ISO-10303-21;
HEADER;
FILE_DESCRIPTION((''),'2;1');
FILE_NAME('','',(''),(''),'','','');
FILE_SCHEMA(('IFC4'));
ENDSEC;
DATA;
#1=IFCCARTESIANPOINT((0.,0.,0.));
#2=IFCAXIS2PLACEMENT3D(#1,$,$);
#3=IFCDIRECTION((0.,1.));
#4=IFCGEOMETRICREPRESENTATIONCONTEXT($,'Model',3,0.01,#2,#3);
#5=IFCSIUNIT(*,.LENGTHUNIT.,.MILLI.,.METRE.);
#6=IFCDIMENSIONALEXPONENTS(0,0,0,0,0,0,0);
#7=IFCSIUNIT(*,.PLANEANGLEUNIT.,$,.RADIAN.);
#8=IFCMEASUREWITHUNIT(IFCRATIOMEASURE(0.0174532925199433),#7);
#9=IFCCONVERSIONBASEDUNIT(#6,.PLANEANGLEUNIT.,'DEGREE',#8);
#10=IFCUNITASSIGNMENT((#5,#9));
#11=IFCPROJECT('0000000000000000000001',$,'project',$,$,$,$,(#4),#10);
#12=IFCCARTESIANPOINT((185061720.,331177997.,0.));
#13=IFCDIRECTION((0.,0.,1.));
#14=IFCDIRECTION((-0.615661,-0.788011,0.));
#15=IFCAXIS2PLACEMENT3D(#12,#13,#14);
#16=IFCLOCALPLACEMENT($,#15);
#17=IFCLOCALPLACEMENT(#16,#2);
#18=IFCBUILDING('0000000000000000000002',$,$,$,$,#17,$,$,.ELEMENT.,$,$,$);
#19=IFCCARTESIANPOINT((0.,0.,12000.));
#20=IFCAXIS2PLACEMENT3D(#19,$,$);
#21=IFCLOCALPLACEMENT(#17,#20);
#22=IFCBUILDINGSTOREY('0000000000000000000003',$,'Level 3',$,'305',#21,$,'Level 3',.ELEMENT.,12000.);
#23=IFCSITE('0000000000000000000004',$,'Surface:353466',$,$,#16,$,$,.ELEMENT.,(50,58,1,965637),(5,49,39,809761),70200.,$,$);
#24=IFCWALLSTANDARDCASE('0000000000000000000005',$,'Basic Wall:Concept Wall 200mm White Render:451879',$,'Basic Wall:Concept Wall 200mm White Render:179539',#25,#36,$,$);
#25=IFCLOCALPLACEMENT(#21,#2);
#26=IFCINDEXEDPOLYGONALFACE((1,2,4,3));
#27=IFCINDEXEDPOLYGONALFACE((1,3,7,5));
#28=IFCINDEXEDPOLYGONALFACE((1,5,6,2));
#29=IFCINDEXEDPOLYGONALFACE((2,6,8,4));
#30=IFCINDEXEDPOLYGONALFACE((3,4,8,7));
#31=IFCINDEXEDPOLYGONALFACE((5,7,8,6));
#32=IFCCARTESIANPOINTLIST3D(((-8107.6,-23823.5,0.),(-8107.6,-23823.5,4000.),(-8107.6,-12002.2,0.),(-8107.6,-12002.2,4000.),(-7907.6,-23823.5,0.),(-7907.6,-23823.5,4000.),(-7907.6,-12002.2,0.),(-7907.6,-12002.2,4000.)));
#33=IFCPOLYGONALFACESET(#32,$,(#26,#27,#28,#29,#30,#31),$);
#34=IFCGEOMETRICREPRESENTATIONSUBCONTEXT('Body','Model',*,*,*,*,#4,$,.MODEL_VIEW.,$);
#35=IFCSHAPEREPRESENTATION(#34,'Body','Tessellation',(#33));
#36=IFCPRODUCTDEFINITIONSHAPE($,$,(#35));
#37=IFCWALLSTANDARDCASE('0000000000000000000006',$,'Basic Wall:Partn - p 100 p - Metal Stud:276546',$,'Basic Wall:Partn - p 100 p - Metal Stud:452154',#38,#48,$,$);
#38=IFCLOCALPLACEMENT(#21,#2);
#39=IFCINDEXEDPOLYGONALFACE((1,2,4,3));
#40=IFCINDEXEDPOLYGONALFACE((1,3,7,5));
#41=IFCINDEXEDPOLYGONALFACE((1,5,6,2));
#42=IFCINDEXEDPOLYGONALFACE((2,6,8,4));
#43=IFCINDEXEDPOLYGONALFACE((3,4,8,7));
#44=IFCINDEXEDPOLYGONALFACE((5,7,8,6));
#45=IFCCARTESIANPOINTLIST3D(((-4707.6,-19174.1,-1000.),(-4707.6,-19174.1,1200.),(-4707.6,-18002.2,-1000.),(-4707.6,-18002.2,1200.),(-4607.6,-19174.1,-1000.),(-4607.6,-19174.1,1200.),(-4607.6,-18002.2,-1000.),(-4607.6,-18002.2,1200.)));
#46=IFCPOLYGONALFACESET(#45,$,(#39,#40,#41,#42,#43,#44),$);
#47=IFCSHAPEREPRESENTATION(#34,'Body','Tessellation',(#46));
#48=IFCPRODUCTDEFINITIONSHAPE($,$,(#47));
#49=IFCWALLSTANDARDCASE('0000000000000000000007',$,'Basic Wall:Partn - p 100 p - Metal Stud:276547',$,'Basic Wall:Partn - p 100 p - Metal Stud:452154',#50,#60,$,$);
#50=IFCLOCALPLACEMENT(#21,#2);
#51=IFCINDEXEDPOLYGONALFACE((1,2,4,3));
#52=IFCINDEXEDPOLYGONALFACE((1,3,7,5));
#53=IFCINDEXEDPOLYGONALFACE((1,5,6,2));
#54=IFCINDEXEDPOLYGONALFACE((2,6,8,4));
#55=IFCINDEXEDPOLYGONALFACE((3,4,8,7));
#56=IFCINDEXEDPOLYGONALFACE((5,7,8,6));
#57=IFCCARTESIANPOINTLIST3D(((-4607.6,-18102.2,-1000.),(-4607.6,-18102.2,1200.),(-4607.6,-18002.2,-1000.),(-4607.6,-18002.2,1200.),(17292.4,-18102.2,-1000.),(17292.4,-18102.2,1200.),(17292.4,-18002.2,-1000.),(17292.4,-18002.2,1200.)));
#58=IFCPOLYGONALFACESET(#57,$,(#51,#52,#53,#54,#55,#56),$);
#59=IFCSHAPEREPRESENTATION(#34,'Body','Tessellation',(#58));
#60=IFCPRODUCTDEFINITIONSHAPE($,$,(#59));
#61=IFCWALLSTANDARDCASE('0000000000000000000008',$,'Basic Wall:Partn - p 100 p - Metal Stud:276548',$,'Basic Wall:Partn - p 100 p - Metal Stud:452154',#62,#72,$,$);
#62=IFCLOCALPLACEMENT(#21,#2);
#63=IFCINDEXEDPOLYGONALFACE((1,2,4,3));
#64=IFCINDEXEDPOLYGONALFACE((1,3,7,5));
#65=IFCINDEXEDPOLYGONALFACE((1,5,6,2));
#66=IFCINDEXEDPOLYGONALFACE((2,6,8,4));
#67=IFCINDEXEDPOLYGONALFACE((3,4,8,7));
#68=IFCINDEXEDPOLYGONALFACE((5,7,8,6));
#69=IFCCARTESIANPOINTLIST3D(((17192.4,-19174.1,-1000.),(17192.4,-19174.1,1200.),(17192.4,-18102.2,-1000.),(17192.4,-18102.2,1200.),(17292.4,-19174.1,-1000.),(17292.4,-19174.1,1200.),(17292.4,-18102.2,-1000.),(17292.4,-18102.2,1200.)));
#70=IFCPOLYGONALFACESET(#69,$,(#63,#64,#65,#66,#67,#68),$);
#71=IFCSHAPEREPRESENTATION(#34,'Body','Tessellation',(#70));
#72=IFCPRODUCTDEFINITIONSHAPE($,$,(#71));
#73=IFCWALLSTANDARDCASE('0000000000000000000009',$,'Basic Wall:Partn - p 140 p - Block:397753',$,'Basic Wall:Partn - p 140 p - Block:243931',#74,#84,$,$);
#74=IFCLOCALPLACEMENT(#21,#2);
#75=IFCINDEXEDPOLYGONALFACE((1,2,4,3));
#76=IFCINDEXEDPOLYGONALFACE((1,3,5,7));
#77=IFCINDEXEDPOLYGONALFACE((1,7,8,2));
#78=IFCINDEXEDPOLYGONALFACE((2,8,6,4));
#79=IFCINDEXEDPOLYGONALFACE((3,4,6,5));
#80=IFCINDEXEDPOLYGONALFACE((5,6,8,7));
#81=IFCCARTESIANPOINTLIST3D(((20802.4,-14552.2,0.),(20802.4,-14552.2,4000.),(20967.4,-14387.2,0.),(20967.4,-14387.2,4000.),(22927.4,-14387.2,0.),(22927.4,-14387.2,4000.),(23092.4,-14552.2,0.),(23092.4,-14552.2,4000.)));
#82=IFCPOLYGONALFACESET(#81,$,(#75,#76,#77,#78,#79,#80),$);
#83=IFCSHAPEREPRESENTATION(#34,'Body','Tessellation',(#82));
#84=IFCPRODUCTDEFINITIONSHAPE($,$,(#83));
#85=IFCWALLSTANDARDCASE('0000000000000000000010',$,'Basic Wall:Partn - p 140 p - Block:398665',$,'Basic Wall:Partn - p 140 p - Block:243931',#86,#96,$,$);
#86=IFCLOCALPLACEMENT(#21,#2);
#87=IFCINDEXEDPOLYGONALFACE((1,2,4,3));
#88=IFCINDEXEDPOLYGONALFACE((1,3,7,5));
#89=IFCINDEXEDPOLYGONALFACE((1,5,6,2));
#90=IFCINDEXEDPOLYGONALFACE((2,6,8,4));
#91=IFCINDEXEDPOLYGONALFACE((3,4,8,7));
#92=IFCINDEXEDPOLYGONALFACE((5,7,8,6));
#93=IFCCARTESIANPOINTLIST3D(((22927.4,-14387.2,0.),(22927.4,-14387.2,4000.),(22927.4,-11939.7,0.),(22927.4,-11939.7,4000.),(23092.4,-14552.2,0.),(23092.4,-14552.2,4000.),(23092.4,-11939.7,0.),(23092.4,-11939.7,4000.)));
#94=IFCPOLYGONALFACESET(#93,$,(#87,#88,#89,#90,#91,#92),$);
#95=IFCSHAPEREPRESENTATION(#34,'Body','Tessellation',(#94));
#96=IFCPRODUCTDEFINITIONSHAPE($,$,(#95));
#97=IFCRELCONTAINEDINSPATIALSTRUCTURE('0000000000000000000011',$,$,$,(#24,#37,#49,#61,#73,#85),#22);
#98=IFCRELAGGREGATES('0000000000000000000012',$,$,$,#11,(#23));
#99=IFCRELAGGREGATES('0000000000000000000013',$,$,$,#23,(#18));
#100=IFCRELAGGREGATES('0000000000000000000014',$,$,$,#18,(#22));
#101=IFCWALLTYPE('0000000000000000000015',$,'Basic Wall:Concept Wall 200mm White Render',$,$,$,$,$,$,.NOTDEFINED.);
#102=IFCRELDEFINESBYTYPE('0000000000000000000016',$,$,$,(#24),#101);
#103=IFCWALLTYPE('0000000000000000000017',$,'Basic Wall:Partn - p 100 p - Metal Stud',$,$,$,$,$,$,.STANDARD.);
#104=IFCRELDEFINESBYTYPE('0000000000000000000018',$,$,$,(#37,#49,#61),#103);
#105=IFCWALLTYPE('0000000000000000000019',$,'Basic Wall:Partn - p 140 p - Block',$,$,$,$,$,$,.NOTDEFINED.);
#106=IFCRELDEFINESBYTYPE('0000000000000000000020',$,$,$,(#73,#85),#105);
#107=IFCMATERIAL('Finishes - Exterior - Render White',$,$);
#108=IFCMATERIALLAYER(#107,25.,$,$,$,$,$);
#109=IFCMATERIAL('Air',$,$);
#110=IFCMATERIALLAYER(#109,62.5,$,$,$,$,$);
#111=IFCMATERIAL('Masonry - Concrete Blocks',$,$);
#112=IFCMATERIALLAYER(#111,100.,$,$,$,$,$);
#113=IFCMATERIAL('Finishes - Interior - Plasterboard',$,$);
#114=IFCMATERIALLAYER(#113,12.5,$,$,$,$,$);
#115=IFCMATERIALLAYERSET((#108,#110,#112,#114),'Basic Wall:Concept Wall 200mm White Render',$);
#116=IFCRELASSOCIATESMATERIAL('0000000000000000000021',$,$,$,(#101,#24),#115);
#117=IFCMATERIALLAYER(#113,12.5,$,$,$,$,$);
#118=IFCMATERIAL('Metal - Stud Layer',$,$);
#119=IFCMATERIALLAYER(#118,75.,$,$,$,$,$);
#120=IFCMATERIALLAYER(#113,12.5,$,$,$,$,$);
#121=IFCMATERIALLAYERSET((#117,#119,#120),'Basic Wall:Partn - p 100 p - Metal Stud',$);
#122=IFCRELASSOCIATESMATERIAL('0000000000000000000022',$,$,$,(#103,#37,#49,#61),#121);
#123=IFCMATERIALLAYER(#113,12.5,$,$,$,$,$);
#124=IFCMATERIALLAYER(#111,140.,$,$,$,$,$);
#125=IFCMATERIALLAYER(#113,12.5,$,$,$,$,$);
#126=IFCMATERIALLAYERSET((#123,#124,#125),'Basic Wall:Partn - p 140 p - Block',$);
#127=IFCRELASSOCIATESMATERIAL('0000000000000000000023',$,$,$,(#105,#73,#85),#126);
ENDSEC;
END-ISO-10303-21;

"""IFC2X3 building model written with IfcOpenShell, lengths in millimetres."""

from ifc_helpers import new_model, entity, si_unit, converted_unit, direction, frame, frame_2d, origin, place, context, subcontext, project, spatial, polyline, rectangle, outline, extrude, clip, halfspace, material, layer, layer_set, layer_usage, type_object, element, save


model = new_model("IFC2X3")

# Units and contexts
model_context = context("Model", 3, precision=0.01, world=origin(), true_north=direction((0.0, 1.0)))
body_context = subcontext(model_context, "Body", "Model", "MODEL_VIEW")
ifc_project = project(units=[si_unit("LENGTHUNIT", "METRE", prefix="MILLI"), converted_unit("PLANEANGLEUNIT", "DEGREE", entity("IfcRatioMeasure", 0.0174532925199433), si_unit("PLANEANGLEUNIT", "RADIAN"), dimensions=[0, 0, 0, 0, 0, 0, 0])], contexts=[model_context])

# Site, building, storey
site_placement = place(None, frame((185061720.0, 331177997.0, 0.0), z_axis=(0.0, 0.0, 1.0), x_axis=(-0.615661, -0.788011, 0.0)))
site = spatial("IfcSite", under=ifc_project, at=site_placement, Name="Surface:353466", CompositionType="ELEMENT", RefLatitude=(50, 58, 1, 965637), RefLongitude=(5, 49, 39, 809761), RefElevation=70200.0)
building_placement = place(site_placement, origin())
building = spatial("IfcBuilding", under=site, at=building_placement, CompositionType="ELEMENT")
storey_placement = place(building_placement, frame((0.0, 0.0, 12000.0)))
storey = spatial("IfcBuildingStorey", under=building, at=storey_placement, Name="Level 3", ObjectType="305", LongName="Level 3", CompositionType="ELEMENT", Elevation=12000.0)

# Walls
ifc_material_1 = material(Name="Masonry - Concrete Blocks")
ifc_material_2 = material(Name="Finishes - Interior - Plasterboard")
ifc_material_3 = material(Name="Finishes - Exterior - Render White")
ifc_layer_1 = layer(ifc_material_3, 25.0)
ifc_material_4 = material(Name="Air")
ifc_layer_2 = layer(ifc_material_4, 62.5)
ifc_layer_3 = layer(ifc_material_1, 100.0)
ifc_layer_4 = layer(ifc_material_2, 12.5)
ifc_layer_set_1 = layer_set([ifc_layer_1, ifc_layer_2, ifc_layer_3, ifc_layer_4], Name="Basic Wall:Concept Wall 200mm White Render")
wall_type_1 = type_object("IfcWallType", Name="Basic Wall:Concept Wall 200mm White Render", PredefinedType="NOTDEFINED", material=ifc_layer_set_1)
ifc_layer_usage_1 = layer_usage(ifc_layer_set_1, "AXIS2", "POSITIVE", -100.0)
wall_1_placement = place(storey_placement, frame((-8007.6, -12002.2, 0.0), z_axis=(0.0, 0.0, 1.0), x_axis=(0.0, -1.0, 0.0)))
element("IfcWallStandardCase", 1, at=wall_1_placement, inside=storey, type_object=wall_type_1, material=ifc_layer_usage_1, Name="Basic Wall:Concept Wall 200mm White Render:451879", ObjectType="Basic Wall:Concept Wall 200mm White Render:179539", context=body_context, shape_type="Clipping", body=[
    clip(clip(extrude(rectangle(XDim=11821.2, YDim=200.0, at=frame_2d((5910.6, 0.0), x_axis=(-1.0, 0.0))), origin(), (0.0, 0.0, 1.0), 4000.0), halfspace(frame((0.0, -100.0, 4000.0), z_axis=(0.0, 0.0, 1.0), x_axis=(0.0, 1.0, 0.0)), False)), halfspace(frame((0.0, 0.0, -8000.0)), True)),
])
ifc_layer_5 = layer(ifc_material_2, 12.5)
ifc_material_5 = material(Name="Metal - Stud Layer")
ifc_layer_6 = layer(ifc_material_5, 75.0)
ifc_layer_7 = layer(ifc_material_2, 12.5)
ifc_layer_set_2 = layer_set([ifc_layer_5, ifc_layer_6, ifc_layer_7], Name="Basic Wall:Partn - p 100 p - Metal Stud")
ifc_layer_usage_2 = layer_usage(ifc_layer_set_2, "AXIS2", "POSITIVE", -50.0)
wall_type_2 = type_object("IfcWallType", Name="Basic Wall:Partn - p 100 p - Metal Stud", PredefinedType="STANDARD", material=ifc_layer_set_2)
wall_2_placement = place(storey_placement, frame((-4657.6, -19174.1, -1000.0), z_axis=(0.0, 0.0, 1.0), x_axis=(0.0, 1.0, 0.0)))
element("IfcWallStandardCase", 2, at=wall_2_placement, inside=storey, type_object=wall_type_2, material=ifc_layer_usage_2, Name="Basic Wall:Partn - p 100 p - Metal Stud:276546", ObjectType="Basic Wall:Partn - p 100 p - Metal Stud:452154", context=body_context, shape_type="SweptSolid", body=[
    extrude(rectangle(XDim=1171.9, YDim=100.0, at=frame_2d((586.0, 0.0), x_axis=(-1.0, 0.0))), origin(), (0.0, 0.0, 1.0), 2200.0),
])
ifc_layer_usage_3 = layer_usage(ifc_layer_set_2, "AXIS2", "POSITIVE", -50.0)
wall_3_placement = place(storey_placement, frame((-4607.6, -18052.2, -1000.0)))
element("IfcWallStandardCase", 3, at=wall_3_placement, inside=storey, type_object=wall_type_2, material=ifc_layer_usage_3, Name="Basic Wall:Partn - p 100 p - Metal Stud:276547", ObjectType="Basic Wall:Partn - p 100 p - Metal Stud:452154", context=body_context, shape_type="SweptSolid", body=[
    extrude(rectangle(XDim=21900.0, YDim=100.0, at=frame_2d((10950.0, 0.0), x_axis=(-1.0, 0.0))), origin(), (0.0, 0.0, 1.0), 2200.0),
])
ifc_layer_usage_4 = layer_usage(ifc_layer_set_2, "AXIS2", "POSITIVE", -50.0)
wall_4_placement = place(storey_placement, frame((17242.4, -18102.2, -1000.0), z_axis=(0.0, 0.0, 1.0), x_axis=(0.0, -1.0, 0.0)))
element("IfcWallStandardCase", 4, at=wall_4_placement, inside=storey, type_object=wall_type_2, material=ifc_layer_usage_4, Name="Basic Wall:Partn - p 100 p - Metal Stud:276548", ObjectType="Basic Wall:Partn - p 100 p - Metal Stud:452154", context=body_context, shape_type="SweptSolid", body=[
    extrude(rectangle(XDim=1071.9, YDim=100.0, at=frame_2d((536.0, 0.0), x_axis=(-1.0, 0.0))), origin(), (0.0, 0.0, 1.0), 2200.0),
])

# Walls
ifc_layer_8 = layer(ifc_material_2, 12.5)
ifc_layer_9 = layer(ifc_material_1, 140.0)
ifc_layer_10 = layer(ifc_material_2, 12.5)
ifc_layer_set_3 = layer_set([ifc_layer_8, ifc_layer_9, ifc_layer_10], Name="Basic Wall:Partn - p 140 p - Block")
ifc_layer_usage_5 = layer_usage(ifc_layer_set_3, "AXIS2", "NEGATIVE", 82.5)
wall_type_3 = type_object("IfcWallType", Name="Basic Wall:Partn - p 140 p - Block", PredefinedType="NOTDEFINED", material=ifc_layer_set_3)
wall_5_placement = place(storey_placement, frame((23092.4, -14469.7, 0.0), z_axis=(0.0, 0.0, 1.0), x_axis=(-1.0, 0.0, 0.0)))
element("IfcWallStandardCase", 5, at=wall_5_placement, inside=storey, type_object=wall_type_3, material=ifc_layer_usage_5, Name="Basic Wall:Partn - p 140 p - Block:397753", ObjectType="Basic Wall:Partn - p 140 p - Block:243931", context=body_context, shape_type="Clipping", body=[
    clip(extrude(outline(polyline([(2125.0, -82.5), (2290.0, 82.5), (0.0, 82.5), (165.0, -82.5), (2125.0, -82.5)])), origin(), (0.0, 0.0, 1.0), 4000.0), halfspace(frame((0.0, 0.0, -12000.0)), True)),
])
ifc_layer_usage_6 = layer_usage(ifc_layer_set_3, "AXIS2", "NEGATIVE", 82.5)
wall_6_placement = place(storey_placement, frame((23009.9, -14552.2, 0.0), z_axis=(0.0, 0.0, 1.0), x_axis=(0.0, 1.0, 0.0)))
element("IfcWallStandardCase", 6, at=wall_6_placement, inside=storey, type_object=wall_type_3, material=ifc_layer_usage_6, Name="Basic Wall:Partn - p 140 p - Block:398665", ObjectType="Basic Wall:Partn - p 140 p - Block:243931", context=body_context, shape_type="Clipping", body=[
    clip(extrude(outline(polyline([(2612.5, -82.5), (2612.5, 82.5), (165.0, 82.5), (0.0, -82.5), (2612.5, -82.5)])), origin(), (0.0, 0.0, 1.0), 4000.0), halfspace(frame((0.0, 0.0, -12000.0)), True)),
])

save(model, "model.ifc")
